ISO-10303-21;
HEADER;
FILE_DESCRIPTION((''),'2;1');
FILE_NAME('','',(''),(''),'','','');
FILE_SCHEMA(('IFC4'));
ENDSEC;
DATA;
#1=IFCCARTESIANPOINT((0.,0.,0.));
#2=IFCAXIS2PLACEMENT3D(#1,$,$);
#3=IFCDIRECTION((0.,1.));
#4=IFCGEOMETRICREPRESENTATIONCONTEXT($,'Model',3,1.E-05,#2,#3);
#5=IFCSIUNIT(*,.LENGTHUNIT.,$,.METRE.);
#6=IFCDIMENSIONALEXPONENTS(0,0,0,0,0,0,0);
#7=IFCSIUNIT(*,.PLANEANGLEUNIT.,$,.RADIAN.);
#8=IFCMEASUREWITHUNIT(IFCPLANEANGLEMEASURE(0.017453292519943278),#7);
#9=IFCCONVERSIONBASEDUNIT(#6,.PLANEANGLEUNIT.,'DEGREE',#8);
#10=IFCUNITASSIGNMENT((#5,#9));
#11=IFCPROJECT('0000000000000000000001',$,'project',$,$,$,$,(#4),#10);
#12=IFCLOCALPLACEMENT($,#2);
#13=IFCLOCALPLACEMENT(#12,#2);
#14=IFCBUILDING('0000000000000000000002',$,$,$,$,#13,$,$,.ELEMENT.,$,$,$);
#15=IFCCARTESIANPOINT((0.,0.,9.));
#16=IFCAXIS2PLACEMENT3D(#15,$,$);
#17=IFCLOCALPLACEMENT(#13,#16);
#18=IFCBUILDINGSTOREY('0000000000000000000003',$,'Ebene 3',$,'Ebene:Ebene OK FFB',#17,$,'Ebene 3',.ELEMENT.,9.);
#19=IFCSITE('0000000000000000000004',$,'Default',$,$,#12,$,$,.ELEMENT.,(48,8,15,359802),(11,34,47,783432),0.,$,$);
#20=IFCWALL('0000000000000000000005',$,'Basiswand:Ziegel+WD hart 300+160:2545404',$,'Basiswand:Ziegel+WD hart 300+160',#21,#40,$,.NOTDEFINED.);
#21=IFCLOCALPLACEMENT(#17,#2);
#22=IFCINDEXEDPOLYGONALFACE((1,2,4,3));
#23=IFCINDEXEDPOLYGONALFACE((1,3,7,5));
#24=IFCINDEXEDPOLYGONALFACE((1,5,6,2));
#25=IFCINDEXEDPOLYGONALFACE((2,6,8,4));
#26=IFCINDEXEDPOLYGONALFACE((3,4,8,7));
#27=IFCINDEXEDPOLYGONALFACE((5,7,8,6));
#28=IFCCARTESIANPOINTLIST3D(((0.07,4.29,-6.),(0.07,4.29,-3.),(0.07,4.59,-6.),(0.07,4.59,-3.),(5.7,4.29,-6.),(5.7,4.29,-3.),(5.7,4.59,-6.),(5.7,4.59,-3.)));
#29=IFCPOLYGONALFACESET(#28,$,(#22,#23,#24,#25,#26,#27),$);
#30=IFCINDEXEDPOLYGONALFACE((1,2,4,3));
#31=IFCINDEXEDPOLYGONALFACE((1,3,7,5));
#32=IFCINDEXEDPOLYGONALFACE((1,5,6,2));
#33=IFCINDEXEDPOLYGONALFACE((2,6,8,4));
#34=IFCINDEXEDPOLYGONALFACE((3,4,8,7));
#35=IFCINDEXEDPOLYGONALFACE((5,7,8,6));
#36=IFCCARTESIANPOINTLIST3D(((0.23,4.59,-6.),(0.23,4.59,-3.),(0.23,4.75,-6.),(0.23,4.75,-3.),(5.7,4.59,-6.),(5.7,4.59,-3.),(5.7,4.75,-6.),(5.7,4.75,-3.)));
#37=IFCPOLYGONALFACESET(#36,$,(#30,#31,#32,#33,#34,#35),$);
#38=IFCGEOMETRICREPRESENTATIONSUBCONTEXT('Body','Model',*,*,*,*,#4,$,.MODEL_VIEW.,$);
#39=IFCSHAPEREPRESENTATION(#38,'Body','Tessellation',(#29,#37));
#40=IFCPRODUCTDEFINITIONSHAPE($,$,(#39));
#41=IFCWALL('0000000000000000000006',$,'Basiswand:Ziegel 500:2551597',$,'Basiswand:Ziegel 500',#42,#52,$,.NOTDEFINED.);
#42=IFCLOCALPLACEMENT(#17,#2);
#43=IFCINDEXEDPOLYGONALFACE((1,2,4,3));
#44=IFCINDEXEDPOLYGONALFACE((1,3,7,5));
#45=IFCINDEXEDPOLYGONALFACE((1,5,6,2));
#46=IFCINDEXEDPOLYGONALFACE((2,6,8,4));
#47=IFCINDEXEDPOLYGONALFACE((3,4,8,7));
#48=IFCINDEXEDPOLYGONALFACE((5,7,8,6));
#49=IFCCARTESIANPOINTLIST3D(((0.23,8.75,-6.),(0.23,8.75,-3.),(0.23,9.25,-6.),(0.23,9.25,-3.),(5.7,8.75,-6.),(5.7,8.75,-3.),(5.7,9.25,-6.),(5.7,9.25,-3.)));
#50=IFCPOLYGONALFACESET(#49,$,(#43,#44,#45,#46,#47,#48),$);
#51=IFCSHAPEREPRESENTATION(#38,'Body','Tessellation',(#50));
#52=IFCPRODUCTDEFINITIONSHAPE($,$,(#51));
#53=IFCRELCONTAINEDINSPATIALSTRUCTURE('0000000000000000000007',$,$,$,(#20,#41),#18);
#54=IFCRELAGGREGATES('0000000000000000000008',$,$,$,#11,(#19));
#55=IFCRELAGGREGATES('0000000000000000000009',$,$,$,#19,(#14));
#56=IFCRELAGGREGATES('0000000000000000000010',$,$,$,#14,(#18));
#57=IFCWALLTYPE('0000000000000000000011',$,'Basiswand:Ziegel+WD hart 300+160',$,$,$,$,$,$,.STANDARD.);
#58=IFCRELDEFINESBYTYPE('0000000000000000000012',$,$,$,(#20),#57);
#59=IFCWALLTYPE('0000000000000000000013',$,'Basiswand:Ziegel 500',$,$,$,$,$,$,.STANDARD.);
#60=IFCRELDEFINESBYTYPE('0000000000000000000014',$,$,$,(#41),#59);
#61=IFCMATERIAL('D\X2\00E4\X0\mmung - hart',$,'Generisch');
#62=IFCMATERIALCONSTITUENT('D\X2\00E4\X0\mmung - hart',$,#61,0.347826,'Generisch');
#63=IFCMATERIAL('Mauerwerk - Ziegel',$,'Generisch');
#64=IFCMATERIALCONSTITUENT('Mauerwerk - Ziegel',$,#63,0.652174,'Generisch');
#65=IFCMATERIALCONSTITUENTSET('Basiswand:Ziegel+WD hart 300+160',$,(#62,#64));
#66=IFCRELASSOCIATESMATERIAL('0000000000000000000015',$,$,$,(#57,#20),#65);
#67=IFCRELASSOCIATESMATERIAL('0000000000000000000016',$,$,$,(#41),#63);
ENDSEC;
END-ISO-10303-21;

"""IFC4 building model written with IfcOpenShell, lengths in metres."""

from ifc_helpers import new_model, entity, si_unit, converted_unit, direction, frame, origin, place, context, subcontext, project, spatial, indexed_curve, outline, extrude, material, constituent, constituent_set, type_object, element, save


model = new_model("IFC4")

# Units and contexts
model_context = context("Model", 3, precision=1e-05, world=origin(), true_north=direction((0.0, 1.0)))
body_context = subcontext(model_context, "Body", "Model", "MODEL_VIEW")
ifc_project = project(units=[si_unit("LENGTHUNIT", "METRE"), converted_unit("PLANEANGLEUNIT", "DEGREE", entity("IfcPlaneAngleMeasure", 0.017453292519943278), si_unit("PLANEANGLEUNIT", "RADIAN"), dimensions=[0, 0, 0, 0, 0, 0, 0])], contexts=[model_context])

# Site, building, storey
site_placement = place(None, origin())
site = spatial("IfcSite", under=ifc_project, at=site_placement, Name="Default", CompositionType="ELEMENT", RefLatitude=(48, 8, 15, 359802), RefLongitude=(11, 34, 47, 783432), RefElevation=0.0)
building_placement = place(site_placement, origin())
building = spatial("IfcBuilding", under=site, at=building_placement, CompositionType="ELEMENT")
storey_placement = place(building_placement, frame((0.0, 0.0, 9.0)))
storey = spatial("IfcBuildingStorey", under=building, at=storey_placement, Name="Ebene 3", ObjectType="Ebene:Ebene OK FFB", LongName="Ebene 3", CompositionType="ELEMENT", Elevation=9.0)

# Shared definitions
ifc_material_1 = material(Name="Dämmung - hart", Category="Generisch")
ifc_constituent_1 = constituent(ifc_material_1, Name="Dämmung - hart", Category="Generisch", fraction=0.347826)
ifc_material_2 = material(Name="Mauerwerk - Ziegel", Category="Generisch")
ifc_constituent_2 = constituent(ifc_material_2, Name="Mauerwerk - Ziegel", Category="Generisch", fraction=0.652174)
ifc_constituent_set_1 = constituent_set(constituents=[ifc_constituent_1, ifc_constituent_2], Name="Basiswand:Ziegel+WD hart 300+160")
wall_type_1 = type_object("IfcWallType", Name="Basiswand:Ziegel+WD hart 300+160", PredefinedType="STANDARD", material=ifc_constituent_set_1)

# Walls
wall_1_placement = place(storey_placement, frame((0.23, 4.52, -6.0)))
element("IfcWall", 1, at=wall_1_placement, inside=storey, type_object=wall_type_1, material=ifc_constituent_set_1, Name="Basiswand:Ziegel+WD hart 300+160:2545404", ObjectType="Basiswand:Ziegel+WD hart 300+160", PredefinedType="NOTDEFINED", context=body_context, shape_type="SweptSolid", body=[
    extrude(outline(indexed_curve([(-0.15, -2.815), (0.15, -2.815), (0.15, 2.815), (-0.15, 2.815), (-0.15, -2.815)], self_intersect=False)), frame((2.655, -0.08, 0.0), z_axis=(0.0, 0.0, 1.0), x_axis=(0.0, 1.0, 0.0)), (0.0, 0.0, 1.0), 3.0),
    extrude(outline(indexed_curve([(-0.08, -2.735), (0.08, -2.735), (0.08, 2.735), (-0.08, 2.735), (-0.08, -2.735)], self_intersect=False)), frame((2.735, 0.15, 0.0), z_axis=(0.0, 0.0, 1.0), x_axis=(0.0, 1.0, 0.0)), (0.0, 0.0, 1.0), 3.0),
])
wall_type_2 = type_object("IfcWallType", Name="Basiswand:Ziegel 500", PredefinedType="STANDARD")
wall_2_placement = place(storey_placement, frame((0.23, 9.0, -6.0)))
element("IfcWall", 2, at=wall_2_placement, inside=storey, type_object=wall_type_2, material=ifc_material_2, Name="Basiswand:Ziegel 500:2551597", ObjectType="Basiswand:Ziegel 500", PredefinedType="NOTDEFINED", context=body_context, shape_type="SweptSolid", body=[
    extrude(outline(indexed_curve([(5.47, 0.25), (0.0, 0.25), (0.0, -0.25), (5.47, -0.25), (5.47, 0.25)], self_intersect=False)), origin(), (0.0, 0.0, 1.0), 3.0),
])

save(model, "model.ifc")
